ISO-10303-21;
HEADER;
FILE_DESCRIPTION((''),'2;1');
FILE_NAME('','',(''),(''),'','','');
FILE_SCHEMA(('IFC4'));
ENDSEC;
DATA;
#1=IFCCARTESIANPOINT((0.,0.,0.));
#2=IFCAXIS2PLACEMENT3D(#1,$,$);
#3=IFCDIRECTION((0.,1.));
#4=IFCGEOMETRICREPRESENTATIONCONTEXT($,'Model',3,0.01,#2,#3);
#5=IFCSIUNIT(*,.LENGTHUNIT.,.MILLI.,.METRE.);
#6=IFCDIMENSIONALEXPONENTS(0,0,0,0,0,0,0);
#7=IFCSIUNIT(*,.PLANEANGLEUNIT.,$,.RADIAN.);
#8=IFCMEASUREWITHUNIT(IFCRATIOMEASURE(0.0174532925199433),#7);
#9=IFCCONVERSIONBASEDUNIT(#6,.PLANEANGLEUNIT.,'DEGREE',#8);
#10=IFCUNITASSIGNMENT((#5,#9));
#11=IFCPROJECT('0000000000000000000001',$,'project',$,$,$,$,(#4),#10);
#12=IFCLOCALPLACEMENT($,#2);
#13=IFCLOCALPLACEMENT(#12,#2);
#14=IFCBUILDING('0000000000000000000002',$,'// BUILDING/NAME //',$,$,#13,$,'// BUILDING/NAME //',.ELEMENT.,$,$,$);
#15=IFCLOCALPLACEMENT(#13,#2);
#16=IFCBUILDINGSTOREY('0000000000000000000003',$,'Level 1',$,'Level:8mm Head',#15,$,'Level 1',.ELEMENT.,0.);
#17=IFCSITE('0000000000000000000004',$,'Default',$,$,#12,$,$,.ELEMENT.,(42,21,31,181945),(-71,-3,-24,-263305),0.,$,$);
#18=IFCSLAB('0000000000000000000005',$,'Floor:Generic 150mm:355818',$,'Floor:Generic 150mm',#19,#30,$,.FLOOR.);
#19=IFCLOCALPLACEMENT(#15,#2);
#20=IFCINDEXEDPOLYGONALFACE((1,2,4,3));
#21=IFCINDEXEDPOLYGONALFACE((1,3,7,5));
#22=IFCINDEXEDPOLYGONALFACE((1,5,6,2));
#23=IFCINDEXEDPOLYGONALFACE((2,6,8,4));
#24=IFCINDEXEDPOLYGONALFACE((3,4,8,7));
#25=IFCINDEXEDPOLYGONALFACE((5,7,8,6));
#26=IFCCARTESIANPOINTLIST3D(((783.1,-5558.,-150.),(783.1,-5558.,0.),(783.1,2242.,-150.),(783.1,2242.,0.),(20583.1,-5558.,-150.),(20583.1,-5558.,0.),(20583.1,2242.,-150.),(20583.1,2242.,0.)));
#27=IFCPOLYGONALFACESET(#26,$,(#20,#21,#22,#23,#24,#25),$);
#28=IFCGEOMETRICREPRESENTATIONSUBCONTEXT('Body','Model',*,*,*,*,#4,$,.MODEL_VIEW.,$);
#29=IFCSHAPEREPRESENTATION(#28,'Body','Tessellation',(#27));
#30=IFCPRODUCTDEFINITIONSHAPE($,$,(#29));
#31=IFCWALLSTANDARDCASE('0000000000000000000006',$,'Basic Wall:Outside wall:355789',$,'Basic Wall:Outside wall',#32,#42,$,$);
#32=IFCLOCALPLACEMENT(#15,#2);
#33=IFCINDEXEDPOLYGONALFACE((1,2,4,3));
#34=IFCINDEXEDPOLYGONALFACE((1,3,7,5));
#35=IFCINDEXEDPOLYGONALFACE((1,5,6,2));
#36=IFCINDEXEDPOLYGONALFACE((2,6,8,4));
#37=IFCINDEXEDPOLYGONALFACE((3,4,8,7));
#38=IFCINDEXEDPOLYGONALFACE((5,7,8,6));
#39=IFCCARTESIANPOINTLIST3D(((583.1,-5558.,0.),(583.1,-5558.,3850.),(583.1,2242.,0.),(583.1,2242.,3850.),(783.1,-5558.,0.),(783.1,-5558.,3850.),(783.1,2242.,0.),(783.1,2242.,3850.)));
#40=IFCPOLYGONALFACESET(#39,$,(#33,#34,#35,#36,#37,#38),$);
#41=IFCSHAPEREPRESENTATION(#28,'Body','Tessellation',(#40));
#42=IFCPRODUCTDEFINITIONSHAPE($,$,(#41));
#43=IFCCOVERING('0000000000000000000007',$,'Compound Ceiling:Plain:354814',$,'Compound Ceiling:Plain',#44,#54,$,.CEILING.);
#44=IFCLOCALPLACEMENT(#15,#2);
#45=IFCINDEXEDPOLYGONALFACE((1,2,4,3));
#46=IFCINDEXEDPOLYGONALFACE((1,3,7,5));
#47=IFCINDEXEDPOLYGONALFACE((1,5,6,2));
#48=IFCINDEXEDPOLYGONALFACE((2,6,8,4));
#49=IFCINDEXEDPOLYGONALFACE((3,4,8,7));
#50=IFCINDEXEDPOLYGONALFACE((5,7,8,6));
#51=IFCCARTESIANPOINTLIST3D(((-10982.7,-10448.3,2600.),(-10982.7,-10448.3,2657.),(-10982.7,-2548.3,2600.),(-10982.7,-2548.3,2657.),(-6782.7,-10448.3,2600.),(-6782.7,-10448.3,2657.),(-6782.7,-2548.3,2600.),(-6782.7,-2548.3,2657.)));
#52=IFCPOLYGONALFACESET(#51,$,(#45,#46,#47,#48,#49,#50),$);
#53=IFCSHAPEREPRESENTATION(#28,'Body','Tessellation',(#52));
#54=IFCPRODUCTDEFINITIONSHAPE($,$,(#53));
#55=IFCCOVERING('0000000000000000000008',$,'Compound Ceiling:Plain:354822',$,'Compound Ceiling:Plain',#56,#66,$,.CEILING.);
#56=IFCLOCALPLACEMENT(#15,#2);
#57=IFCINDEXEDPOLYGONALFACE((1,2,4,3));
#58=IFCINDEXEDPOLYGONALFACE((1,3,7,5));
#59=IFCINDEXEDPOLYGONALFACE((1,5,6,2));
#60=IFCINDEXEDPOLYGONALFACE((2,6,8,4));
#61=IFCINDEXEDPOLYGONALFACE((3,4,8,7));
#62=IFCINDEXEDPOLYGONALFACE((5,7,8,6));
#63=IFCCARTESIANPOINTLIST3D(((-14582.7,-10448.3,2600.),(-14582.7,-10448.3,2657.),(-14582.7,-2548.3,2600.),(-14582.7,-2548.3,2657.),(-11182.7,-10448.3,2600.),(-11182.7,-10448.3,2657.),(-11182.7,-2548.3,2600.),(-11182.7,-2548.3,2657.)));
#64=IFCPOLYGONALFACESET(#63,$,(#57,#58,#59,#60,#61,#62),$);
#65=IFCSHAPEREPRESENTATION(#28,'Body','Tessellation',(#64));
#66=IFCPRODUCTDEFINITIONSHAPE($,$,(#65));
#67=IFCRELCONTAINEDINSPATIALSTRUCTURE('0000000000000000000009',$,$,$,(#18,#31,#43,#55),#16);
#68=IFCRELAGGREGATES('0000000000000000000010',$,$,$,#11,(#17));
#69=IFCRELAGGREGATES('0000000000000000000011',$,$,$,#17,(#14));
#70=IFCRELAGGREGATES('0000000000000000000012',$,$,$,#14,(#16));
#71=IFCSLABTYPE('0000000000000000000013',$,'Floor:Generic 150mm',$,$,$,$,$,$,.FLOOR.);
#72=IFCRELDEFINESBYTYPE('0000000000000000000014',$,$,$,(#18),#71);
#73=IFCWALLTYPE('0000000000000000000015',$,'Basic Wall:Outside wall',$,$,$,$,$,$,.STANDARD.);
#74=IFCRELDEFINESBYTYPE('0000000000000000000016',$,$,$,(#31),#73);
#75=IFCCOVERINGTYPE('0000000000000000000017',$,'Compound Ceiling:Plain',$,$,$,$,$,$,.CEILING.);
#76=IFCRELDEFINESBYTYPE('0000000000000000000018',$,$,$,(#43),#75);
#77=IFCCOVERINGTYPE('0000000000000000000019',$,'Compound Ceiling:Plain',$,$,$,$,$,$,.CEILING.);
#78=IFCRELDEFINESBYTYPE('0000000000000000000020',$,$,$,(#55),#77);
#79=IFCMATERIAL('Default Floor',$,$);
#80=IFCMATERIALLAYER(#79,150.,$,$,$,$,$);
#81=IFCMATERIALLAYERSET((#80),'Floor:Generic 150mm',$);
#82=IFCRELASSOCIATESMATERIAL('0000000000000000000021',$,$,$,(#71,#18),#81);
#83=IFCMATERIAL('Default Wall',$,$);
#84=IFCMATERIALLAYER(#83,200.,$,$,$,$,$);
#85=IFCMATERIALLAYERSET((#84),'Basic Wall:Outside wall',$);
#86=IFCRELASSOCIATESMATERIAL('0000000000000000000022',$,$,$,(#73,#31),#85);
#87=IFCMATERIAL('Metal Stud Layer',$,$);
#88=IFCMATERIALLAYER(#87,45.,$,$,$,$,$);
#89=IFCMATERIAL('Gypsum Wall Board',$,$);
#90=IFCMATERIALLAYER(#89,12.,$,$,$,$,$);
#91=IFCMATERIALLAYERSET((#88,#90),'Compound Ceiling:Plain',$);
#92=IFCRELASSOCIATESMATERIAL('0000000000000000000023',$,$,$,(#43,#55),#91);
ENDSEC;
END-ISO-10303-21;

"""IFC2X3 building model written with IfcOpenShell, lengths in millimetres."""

from ifc_helpers import new_model, entity, si_unit, converted_unit, direction, frame, frame_2d, origin, place, context, subcontext, project, spatial, rectangle, extrude, material, layer, layer_set, layer_usage, type_object, element, save


model = new_model("IFC2X3")

# Units and contexts
model_context = context("Model", 3, precision=0.01, world=origin(), true_north=direction((0.0, 1.0)))
body_context = subcontext(model_context, "Body", "Model", "MODEL_VIEW")
ifc_project = project(units=[si_unit("LENGTHUNIT", "METRE", prefix="MILLI"), converted_unit("PLANEANGLEUNIT", "DEGREE", entity("IfcRatioMeasure", 0.0174532925199433), si_unit("PLANEANGLEUNIT", "RADIAN"), dimensions=[0, 0, 0, 0, 0, 0, 0])], contexts=[model_context])

# Site, building, storey
site_placement = place(None, origin())
site = spatial("IfcSite", under=ifc_project, at=site_placement, Name="Default", CompositionType="ELEMENT", RefLatitude=(42, 21, 31, 181945), RefLongitude=(-71, -3, -24, -263305), RefElevation=0.0)
building_placement = place(site_placement, origin())
building = spatial("IfcBuilding", under=site, at=building_placement, Name="// BUILDING/NAME //", LongName="// BUILDING/NAME //", CompositionType="ELEMENT")
storey_placement = place(building_placement, origin())
storey = spatial("IfcBuildingStorey", under=building, at=storey_placement, Name="Level 1", ObjectType="Level:8mm Head", LongName="Level 1", CompositionType="ELEMENT", Elevation=0.0)

# Slab
ifc_material_1 = material(Name="Default Floor")
ifc_layer_1 = layer(ifc_material_1, 150.0)
ifc_layer_set_1 = layer_set([ifc_layer_1], Name="Floor:Generic 150mm")
ifc_layer_usage_1 = layer_usage(ifc_layer_set_1, "AXIS3", "POSITIVE", 0.0)
slab_type = type_object("IfcSlabType", Name="Floor:Generic 150mm", PredefinedType="FLOOR", material=ifc_layer_set_1)
slab_placement = place(storey_placement, origin())
element("IfcSlab", 1, at=slab_placement, inside=storey, type_object=slab_type, material=ifc_layer_usage_1, Name="Floor:Generic 150mm:355818", ObjectType="Floor:Generic 150mm", PredefinedType="FLOOR", context=body_context, shape_type="SweptSolid", body=[
    extrude(rectangle(XDim=7800.0, YDim=19800.0, at=frame_2d((0.0, 0.0), x_axis=(1.0, 0.0))), frame((10683.1, -1658.0, 0.0), z_axis=(0.0, 0.0, -1.0), x_axis=(0.0, 1.0, 0.0)), (0.0, 0.0, 1.0), 150.0),
])

# Wall
ifc_material_2 = material(Name="Default Wall")
ifc_layer_2 = layer(ifc_material_2, 200.0)
ifc_layer_set_2 = layer_set([ifc_layer_2], Name="Basic Wall:Outside wall")
ifc_layer_usage_2 = layer_usage(ifc_layer_set_2, "AXIS2", "NEGATIVE", 100.0)
wall_type = type_object("IfcWallType", Name="Basic Wall:Outside wall", PredefinedType="STANDARD", material=ifc_layer_set_2)
wall_placement = place(storey_placement, frame((683.1, 2242.0, 0.0), z_axis=(0.0, 0.0, 1.0), x_axis=(0.0, -1.0, 0.0)))
element("IfcWallStandardCase", 2, at=wall_placement, inside=storey, type_object=wall_type, material=ifc_layer_usage_2, Name="Basic Wall:Outside wall:355789", ObjectType="Basic Wall:Outside wall", context=body_context, shape_type="SweptSolid", body=[
    extrude(rectangle(XDim=7800.0, YDim=200.0, at=frame_2d((3900.0, 0.0), x_axis=(-1.0, 0.0))), origin(), (0.0, 0.0, 1.0), 3850.0),
])

# Coverings
ifc_material_3 = material(Name="Metal Stud Layer")
ifc_layer_3 = layer(ifc_material_3, 45.0)
ifc_material_4 = material(Name="Gypsum Wall Board")
ifc_layer_4 = layer(ifc_material_4, 12.0)
ifc_layer_set_3 = layer_set([ifc_layer_3, ifc_layer_4], Name="Compound Ceiling:Plain")
ifc_layer_usage_3 = layer_usage(ifc_layer_set_3, "AXIS3", "POSITIVE", 0.0)
covering_type_1 = type_object("IfcCoveringType", Name="Compound Ceiling:Plain", PredefinedType="CEILING")
covering_1_placement = place(storey_placement, origin())
element("IfcCovering", 3, at=covering_1_placement, inside=storey, type_object=covering_type_1, material=ifc_layer_usage_3, Name="Compound Ceiling:Plain:354814", ObjectType="Compound Ceiling:Plain", PredefinedType="CEILING", context=body_context, shape_type="SweptSolid", body=[
    extrude(rectangle(XDim=4200.0, YDim=7900.0, at=frame_2d((0.0, 0.0), x_axis=(1.0, 0.0))), frame((-8882.7, -6498.3, 2600.0), z_axis=(0.0, 0.0, 1.0), x_axis=(-1.0, 0.0, 0.0)), (0.0, 0.0, 1.0), 57.0),
])
ifc_layer_usage_4 = layer_usage(ifc_layer_set_3, "AXIS3", "POSITIVE", 0.0)
covering_type_2 = type_object("IfcCoveringType", Name="Compound Ceiling:Plain", PredefinedType="CEILING")
covering_2_placement = place(storey_placement, origin())
element("IfcCovering", 4, at=covering_2_placement, inside=storey, type_object=covering_type_2, material=ifc_layer_usage_4, Name="Compound Ceiling:Plain:354822", ObjectType="Compound Ceiling:Plain", PredefinedType="CEILING", context=body_context, shape_type="SweptSolid", body=[
    extrude(rectangle(XDim=7900.0, YDim=3400.0, at=frame_2d((0.0, 0.0), x_axis=(1.0, 0.0))), frame((-12882.7, -6498.3, 2600.0), z_axis=(0.0, 0.0, 1.0), x_axis=(0.0, 1.0, 0.0)), (0.0, 0.0, 1.0), 57.0),
])

save(model, "model.ifc")
